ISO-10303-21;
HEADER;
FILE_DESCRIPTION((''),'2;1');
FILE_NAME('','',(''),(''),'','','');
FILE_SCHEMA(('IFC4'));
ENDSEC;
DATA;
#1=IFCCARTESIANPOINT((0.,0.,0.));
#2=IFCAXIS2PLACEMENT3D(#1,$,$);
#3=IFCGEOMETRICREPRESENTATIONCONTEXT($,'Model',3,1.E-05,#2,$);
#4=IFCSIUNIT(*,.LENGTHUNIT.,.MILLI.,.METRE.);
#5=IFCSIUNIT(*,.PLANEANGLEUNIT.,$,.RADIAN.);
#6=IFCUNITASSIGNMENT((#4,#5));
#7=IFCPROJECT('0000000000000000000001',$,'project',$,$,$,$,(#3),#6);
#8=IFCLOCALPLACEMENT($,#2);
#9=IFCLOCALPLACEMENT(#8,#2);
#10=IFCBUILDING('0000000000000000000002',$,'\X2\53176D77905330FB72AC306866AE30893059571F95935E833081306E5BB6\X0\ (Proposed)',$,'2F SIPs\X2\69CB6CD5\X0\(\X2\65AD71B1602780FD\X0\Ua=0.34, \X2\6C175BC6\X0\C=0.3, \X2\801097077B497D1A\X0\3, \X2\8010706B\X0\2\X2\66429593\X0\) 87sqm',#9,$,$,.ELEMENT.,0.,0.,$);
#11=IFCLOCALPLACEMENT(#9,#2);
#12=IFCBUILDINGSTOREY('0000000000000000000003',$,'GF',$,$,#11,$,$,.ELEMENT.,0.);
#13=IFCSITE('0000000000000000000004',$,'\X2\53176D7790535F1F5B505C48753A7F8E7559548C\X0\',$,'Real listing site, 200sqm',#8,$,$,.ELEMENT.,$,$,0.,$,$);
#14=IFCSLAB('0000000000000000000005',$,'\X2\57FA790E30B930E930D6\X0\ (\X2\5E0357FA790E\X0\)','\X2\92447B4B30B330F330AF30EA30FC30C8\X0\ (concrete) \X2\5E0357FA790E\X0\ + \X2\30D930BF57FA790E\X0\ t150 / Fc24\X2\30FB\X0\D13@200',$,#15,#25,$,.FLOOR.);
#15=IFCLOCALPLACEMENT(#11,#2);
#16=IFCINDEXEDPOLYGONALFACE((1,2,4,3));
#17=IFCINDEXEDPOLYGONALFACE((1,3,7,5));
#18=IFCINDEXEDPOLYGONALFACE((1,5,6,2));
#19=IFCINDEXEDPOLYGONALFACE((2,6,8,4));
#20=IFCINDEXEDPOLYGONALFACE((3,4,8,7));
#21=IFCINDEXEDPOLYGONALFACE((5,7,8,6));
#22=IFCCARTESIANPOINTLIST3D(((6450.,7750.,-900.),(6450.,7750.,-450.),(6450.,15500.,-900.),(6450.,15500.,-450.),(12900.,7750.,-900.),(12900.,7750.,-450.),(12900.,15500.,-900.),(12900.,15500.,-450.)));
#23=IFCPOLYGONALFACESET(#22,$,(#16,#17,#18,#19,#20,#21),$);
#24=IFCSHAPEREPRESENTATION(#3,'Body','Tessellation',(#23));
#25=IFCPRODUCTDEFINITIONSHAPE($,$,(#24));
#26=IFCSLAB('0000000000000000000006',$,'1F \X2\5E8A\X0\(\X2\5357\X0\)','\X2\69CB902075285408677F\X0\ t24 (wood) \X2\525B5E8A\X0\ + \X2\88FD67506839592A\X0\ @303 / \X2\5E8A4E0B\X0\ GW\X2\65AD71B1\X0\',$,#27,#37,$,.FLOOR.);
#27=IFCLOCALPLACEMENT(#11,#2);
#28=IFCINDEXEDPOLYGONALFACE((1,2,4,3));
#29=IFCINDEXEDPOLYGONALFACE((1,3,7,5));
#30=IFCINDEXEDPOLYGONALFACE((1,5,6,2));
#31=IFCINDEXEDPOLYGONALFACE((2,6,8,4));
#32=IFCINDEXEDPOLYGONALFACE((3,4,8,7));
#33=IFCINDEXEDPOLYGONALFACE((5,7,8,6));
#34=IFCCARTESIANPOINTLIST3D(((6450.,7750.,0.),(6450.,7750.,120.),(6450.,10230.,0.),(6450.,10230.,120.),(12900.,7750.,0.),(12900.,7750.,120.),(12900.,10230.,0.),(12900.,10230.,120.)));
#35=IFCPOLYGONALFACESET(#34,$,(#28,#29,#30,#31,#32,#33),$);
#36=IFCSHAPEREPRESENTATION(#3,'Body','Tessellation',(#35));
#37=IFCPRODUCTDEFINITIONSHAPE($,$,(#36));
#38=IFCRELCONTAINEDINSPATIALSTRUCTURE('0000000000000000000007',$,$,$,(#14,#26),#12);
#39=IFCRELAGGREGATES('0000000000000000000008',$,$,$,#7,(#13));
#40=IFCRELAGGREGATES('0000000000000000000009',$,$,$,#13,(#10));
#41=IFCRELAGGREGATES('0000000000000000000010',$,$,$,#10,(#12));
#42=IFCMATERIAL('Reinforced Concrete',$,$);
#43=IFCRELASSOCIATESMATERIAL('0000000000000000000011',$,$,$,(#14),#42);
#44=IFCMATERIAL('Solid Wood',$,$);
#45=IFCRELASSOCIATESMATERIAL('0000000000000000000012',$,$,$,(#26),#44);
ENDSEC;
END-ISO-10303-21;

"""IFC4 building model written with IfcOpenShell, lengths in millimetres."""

from ifc_helpers import new_model, si_unit, frame, frame_2d, origin, place, context, project, spatial, rectangle, extrude, material, element, save


model = new_model("IFC4")

# Units and contexts
model_context = context("Model", 3, precision=1e-05, world=origin())
ifc_project = project(units=[si_unit("LENGTHUNIT", "METRE", prefix="MILLI"), si_unit("PLANEANGLEUNIT", "RADIAN")], contexts=[model_context])

# Site, building, storey
site_placement = place(None, origin())
site = spatial("IfcSite", under=ifc_project, at=site_placement, Name="北海道弟子屈町美留和", ObjectType="Real listing site, 200sqm", CompositionType="ELEMENT", RefElevation=0.0)
building_placement = place(site_placement, origin())
building = spatial("IfcBuilding", under=site, at=building_placement, Name="北海道・犬と暮らす土間広めの家 (Proposed)", ObjectType="2F SIPs構法(断熱性能Ua=0.34, 気密C=0.3, 耐震等級3, 耐火2時間) 87sqm", CompositionType="ELEMENT", ElevationOfRefHeight=0.0, ElevationOfTerrain=0.0)
storey_placement = place(building_placement, origin())
storey = spatial("IfcBuildingStorey", under=building, at=storey_placement, Name="GF", CompositionType="ELEMENT", Elevation=0.0)

# Shared definitions
ifc_material_1 = material(Name="Solid Wood")

# Slabs
ifc_material_2 = material(Name="Reinforced Concrete")
slab_1_placement = place(storey_placement, frame((3225.0, 3875.0, -450.0)))
element("IfcSlab", 1, at=slab_1_placement, inside=storey, material=ifc_material_2, Name="基礎スラブ (布基礎)", Description="鉄筋コンクリート (concrete) 布基礎 + ベタ基礎 t150 / Fc24・D13@200", PredefinedType="FLOOR", context=model_context, shape_type="SweptSolid", body=[
    extrude(rectangle(XDim=6450.0, YDim=7750.0, at=frame_2d((3225.0, 3875.0))), frame((3225.0, 3875.0, -450.0)), (0.0, 0.0, 1.0), 450.0),
])
slab_2_placement = place(storey_placement, frame((3225.0, 3875.0, 0.0)))
element("IfcSlab", 2, at=slab_2_placement, inside=storey, material=ifc_material_1, Name="1F 床(南)", Description="構造用合板 t24 (wood) 剛床 + 製材根太 @303 / 床下 GW断熱", PredefinedType="FLOOR", context=model_context, shape_type="SweptSolid", body=[
    extrude(rectangle(XDim=6450.0, YDim=2480.0, at=frame_2d((3225.0, 1240.0))), frame((3225.0, 3875.0, 0.0)), (0.0, 0.0, 1.0), 120.0),
])

save(model, "model.ifc")
